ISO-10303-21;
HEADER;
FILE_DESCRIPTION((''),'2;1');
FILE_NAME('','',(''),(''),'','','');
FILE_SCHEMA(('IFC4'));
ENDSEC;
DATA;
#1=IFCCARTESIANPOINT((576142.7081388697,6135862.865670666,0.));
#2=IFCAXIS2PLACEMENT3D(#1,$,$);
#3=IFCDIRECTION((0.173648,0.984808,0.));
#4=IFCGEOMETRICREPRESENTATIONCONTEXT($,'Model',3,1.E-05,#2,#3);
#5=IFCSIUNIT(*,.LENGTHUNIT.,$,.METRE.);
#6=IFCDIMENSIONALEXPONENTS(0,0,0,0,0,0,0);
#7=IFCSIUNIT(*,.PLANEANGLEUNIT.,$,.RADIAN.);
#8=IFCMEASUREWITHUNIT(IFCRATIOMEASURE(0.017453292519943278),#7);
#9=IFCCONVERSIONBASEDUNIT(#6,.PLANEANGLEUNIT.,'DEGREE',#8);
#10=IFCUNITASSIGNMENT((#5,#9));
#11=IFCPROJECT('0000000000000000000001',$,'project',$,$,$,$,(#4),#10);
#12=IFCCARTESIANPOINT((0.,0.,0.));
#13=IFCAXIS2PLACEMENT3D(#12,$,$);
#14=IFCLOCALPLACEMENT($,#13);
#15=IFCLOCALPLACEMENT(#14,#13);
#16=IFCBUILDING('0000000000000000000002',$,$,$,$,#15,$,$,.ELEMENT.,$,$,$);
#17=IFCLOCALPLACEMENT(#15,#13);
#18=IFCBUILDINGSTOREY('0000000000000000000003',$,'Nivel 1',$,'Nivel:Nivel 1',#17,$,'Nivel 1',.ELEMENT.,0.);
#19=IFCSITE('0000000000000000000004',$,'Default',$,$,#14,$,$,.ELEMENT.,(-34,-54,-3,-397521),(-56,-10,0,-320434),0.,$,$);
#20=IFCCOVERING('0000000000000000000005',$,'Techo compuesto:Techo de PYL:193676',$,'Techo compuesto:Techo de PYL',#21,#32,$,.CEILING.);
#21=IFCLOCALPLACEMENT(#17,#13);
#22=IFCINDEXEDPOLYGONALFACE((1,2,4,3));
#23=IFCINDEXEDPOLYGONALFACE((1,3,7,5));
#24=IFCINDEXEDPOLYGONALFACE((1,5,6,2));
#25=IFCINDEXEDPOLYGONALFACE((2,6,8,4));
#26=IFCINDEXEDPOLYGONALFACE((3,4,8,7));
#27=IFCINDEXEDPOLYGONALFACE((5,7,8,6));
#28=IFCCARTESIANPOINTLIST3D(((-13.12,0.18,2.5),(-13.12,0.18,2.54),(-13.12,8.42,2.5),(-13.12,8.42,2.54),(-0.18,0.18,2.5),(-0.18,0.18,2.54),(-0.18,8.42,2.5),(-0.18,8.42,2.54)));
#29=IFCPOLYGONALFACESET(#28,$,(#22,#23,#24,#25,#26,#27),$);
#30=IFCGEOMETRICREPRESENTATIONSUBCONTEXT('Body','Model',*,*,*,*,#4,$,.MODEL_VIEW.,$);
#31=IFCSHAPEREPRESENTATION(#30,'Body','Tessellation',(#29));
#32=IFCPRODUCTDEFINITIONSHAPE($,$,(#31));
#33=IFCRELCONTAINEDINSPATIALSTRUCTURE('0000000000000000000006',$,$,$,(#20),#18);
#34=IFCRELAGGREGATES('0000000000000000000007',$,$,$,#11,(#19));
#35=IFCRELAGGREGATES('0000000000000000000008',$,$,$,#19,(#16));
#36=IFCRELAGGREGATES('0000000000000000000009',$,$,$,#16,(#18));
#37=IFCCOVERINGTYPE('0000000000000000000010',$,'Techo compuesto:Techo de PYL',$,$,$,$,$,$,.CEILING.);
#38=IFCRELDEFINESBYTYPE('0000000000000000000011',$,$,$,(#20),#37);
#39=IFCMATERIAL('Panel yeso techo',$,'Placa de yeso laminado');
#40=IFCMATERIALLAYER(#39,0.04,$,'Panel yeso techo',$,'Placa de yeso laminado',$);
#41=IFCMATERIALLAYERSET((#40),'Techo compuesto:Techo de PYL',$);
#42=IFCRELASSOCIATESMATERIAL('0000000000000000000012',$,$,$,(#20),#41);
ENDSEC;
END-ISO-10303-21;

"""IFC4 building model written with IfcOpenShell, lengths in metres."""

from ifc_helpers import new_model, entity, si_unit, converted_unit, direction, frame, frame_2d, origin, place, context, subcontext, project, spatial, rectangle, extrude, material, layer, layer_set, layer_usage, type_object, element, save


model = new_model("IFC4")

# Units and contexts
model_context = context("Model", 3, precision=1e-05, world=frame((576142.7081388697, 6135862.865670666, 0.0)), true_north=direction((0.173648, 0.984808, 0.0)))
body_context = subcontext(model_context, "Body", "Model", "MODEL_VIEW")
ifc_project = project(units=[si_unit("LENGTHUNIT", "METRE"), converted_unit("PLANEANGLEUNIT", "DEGREE", entity("IfcRatioMeasure", 0.017453292519943278), si_unit("PLANEANGLEUNIT", "RADIAN"), dimensions=[0, 0, 0, 0, 0, 0, 0])], contexts=[model_context])

# Site, building, storey
site_placement = place(None, origin())
site = spatial("IfcSite", under=ifc_project, at=site_placement, Name="Default", CompositionType="ELEMENT", RefLatitude=(-34, -54, -3, -397521), RefLongitude=(-56, -10, 0, -320434), RefElevation=0.0)
building_placement = place(site_placement, origin())
building = spatial("IfcBuilding", under=site, at=building_placement, CompositionType="ELEMENT")
storey_placement = place(building_placement, origin())
storey = spatial("IfcBuildingStorey", under=building, at=storey_placement, Name="Nivel 1", ObjectType="Nivel:Nivel 1", LongName="Nivel 1", CompositionType="ELEMENT", Elevation=0.0)

# Covering
ifc_material_1 = material(Name="Panel yeso techo", Category="Placa de yeso laminado")
ifc_layer_1 = layer(ifc_material_1, 0.04, Name="Panel yeso techo", Category="Placa de yeso laminado")
ifc_layer_set_1 = layer_set([ifc_layer_1], Name="Techo compuesto:Techo de PYL")
ifc_layer_usage_1 = layer_usage(ifc_layer_set_1, "AXIS3", "POSITIVE", 0.0)
covering_type = type_object("IfcCoveringType", Name="Techo compuesto:Techo de PYL", PredefinedType="CEILING")
covering_placement = place(storey_placement, frame((-13.12, 0.18, 2.5)))
element("IfcCovering", 1, at=covering_placement, inside=storey, type_object=covering_type, material=ifc_layer_usage_1, Name="Techo compuesto:Techo de PYL:193676", ObjectType="Techo compuesto:Techo de PYL", PredefinedType="CEILING", context=body_context, shape_type="SweptSolid", body=[
    extrude(rectangle(XDim=12.94, YDim=8.24, at=frame_2d((0.0, 0.0), x_axis=(1.0, 0.0))), frame((6.47, 4.12, 0.0), z_axis=(0.0, 0.0, 1.0), x_axis=(-1.0, 0.0, 0.0)), (0.0, 0.0, 1.0), 0.04),
])

save(model, "model.ifc")
